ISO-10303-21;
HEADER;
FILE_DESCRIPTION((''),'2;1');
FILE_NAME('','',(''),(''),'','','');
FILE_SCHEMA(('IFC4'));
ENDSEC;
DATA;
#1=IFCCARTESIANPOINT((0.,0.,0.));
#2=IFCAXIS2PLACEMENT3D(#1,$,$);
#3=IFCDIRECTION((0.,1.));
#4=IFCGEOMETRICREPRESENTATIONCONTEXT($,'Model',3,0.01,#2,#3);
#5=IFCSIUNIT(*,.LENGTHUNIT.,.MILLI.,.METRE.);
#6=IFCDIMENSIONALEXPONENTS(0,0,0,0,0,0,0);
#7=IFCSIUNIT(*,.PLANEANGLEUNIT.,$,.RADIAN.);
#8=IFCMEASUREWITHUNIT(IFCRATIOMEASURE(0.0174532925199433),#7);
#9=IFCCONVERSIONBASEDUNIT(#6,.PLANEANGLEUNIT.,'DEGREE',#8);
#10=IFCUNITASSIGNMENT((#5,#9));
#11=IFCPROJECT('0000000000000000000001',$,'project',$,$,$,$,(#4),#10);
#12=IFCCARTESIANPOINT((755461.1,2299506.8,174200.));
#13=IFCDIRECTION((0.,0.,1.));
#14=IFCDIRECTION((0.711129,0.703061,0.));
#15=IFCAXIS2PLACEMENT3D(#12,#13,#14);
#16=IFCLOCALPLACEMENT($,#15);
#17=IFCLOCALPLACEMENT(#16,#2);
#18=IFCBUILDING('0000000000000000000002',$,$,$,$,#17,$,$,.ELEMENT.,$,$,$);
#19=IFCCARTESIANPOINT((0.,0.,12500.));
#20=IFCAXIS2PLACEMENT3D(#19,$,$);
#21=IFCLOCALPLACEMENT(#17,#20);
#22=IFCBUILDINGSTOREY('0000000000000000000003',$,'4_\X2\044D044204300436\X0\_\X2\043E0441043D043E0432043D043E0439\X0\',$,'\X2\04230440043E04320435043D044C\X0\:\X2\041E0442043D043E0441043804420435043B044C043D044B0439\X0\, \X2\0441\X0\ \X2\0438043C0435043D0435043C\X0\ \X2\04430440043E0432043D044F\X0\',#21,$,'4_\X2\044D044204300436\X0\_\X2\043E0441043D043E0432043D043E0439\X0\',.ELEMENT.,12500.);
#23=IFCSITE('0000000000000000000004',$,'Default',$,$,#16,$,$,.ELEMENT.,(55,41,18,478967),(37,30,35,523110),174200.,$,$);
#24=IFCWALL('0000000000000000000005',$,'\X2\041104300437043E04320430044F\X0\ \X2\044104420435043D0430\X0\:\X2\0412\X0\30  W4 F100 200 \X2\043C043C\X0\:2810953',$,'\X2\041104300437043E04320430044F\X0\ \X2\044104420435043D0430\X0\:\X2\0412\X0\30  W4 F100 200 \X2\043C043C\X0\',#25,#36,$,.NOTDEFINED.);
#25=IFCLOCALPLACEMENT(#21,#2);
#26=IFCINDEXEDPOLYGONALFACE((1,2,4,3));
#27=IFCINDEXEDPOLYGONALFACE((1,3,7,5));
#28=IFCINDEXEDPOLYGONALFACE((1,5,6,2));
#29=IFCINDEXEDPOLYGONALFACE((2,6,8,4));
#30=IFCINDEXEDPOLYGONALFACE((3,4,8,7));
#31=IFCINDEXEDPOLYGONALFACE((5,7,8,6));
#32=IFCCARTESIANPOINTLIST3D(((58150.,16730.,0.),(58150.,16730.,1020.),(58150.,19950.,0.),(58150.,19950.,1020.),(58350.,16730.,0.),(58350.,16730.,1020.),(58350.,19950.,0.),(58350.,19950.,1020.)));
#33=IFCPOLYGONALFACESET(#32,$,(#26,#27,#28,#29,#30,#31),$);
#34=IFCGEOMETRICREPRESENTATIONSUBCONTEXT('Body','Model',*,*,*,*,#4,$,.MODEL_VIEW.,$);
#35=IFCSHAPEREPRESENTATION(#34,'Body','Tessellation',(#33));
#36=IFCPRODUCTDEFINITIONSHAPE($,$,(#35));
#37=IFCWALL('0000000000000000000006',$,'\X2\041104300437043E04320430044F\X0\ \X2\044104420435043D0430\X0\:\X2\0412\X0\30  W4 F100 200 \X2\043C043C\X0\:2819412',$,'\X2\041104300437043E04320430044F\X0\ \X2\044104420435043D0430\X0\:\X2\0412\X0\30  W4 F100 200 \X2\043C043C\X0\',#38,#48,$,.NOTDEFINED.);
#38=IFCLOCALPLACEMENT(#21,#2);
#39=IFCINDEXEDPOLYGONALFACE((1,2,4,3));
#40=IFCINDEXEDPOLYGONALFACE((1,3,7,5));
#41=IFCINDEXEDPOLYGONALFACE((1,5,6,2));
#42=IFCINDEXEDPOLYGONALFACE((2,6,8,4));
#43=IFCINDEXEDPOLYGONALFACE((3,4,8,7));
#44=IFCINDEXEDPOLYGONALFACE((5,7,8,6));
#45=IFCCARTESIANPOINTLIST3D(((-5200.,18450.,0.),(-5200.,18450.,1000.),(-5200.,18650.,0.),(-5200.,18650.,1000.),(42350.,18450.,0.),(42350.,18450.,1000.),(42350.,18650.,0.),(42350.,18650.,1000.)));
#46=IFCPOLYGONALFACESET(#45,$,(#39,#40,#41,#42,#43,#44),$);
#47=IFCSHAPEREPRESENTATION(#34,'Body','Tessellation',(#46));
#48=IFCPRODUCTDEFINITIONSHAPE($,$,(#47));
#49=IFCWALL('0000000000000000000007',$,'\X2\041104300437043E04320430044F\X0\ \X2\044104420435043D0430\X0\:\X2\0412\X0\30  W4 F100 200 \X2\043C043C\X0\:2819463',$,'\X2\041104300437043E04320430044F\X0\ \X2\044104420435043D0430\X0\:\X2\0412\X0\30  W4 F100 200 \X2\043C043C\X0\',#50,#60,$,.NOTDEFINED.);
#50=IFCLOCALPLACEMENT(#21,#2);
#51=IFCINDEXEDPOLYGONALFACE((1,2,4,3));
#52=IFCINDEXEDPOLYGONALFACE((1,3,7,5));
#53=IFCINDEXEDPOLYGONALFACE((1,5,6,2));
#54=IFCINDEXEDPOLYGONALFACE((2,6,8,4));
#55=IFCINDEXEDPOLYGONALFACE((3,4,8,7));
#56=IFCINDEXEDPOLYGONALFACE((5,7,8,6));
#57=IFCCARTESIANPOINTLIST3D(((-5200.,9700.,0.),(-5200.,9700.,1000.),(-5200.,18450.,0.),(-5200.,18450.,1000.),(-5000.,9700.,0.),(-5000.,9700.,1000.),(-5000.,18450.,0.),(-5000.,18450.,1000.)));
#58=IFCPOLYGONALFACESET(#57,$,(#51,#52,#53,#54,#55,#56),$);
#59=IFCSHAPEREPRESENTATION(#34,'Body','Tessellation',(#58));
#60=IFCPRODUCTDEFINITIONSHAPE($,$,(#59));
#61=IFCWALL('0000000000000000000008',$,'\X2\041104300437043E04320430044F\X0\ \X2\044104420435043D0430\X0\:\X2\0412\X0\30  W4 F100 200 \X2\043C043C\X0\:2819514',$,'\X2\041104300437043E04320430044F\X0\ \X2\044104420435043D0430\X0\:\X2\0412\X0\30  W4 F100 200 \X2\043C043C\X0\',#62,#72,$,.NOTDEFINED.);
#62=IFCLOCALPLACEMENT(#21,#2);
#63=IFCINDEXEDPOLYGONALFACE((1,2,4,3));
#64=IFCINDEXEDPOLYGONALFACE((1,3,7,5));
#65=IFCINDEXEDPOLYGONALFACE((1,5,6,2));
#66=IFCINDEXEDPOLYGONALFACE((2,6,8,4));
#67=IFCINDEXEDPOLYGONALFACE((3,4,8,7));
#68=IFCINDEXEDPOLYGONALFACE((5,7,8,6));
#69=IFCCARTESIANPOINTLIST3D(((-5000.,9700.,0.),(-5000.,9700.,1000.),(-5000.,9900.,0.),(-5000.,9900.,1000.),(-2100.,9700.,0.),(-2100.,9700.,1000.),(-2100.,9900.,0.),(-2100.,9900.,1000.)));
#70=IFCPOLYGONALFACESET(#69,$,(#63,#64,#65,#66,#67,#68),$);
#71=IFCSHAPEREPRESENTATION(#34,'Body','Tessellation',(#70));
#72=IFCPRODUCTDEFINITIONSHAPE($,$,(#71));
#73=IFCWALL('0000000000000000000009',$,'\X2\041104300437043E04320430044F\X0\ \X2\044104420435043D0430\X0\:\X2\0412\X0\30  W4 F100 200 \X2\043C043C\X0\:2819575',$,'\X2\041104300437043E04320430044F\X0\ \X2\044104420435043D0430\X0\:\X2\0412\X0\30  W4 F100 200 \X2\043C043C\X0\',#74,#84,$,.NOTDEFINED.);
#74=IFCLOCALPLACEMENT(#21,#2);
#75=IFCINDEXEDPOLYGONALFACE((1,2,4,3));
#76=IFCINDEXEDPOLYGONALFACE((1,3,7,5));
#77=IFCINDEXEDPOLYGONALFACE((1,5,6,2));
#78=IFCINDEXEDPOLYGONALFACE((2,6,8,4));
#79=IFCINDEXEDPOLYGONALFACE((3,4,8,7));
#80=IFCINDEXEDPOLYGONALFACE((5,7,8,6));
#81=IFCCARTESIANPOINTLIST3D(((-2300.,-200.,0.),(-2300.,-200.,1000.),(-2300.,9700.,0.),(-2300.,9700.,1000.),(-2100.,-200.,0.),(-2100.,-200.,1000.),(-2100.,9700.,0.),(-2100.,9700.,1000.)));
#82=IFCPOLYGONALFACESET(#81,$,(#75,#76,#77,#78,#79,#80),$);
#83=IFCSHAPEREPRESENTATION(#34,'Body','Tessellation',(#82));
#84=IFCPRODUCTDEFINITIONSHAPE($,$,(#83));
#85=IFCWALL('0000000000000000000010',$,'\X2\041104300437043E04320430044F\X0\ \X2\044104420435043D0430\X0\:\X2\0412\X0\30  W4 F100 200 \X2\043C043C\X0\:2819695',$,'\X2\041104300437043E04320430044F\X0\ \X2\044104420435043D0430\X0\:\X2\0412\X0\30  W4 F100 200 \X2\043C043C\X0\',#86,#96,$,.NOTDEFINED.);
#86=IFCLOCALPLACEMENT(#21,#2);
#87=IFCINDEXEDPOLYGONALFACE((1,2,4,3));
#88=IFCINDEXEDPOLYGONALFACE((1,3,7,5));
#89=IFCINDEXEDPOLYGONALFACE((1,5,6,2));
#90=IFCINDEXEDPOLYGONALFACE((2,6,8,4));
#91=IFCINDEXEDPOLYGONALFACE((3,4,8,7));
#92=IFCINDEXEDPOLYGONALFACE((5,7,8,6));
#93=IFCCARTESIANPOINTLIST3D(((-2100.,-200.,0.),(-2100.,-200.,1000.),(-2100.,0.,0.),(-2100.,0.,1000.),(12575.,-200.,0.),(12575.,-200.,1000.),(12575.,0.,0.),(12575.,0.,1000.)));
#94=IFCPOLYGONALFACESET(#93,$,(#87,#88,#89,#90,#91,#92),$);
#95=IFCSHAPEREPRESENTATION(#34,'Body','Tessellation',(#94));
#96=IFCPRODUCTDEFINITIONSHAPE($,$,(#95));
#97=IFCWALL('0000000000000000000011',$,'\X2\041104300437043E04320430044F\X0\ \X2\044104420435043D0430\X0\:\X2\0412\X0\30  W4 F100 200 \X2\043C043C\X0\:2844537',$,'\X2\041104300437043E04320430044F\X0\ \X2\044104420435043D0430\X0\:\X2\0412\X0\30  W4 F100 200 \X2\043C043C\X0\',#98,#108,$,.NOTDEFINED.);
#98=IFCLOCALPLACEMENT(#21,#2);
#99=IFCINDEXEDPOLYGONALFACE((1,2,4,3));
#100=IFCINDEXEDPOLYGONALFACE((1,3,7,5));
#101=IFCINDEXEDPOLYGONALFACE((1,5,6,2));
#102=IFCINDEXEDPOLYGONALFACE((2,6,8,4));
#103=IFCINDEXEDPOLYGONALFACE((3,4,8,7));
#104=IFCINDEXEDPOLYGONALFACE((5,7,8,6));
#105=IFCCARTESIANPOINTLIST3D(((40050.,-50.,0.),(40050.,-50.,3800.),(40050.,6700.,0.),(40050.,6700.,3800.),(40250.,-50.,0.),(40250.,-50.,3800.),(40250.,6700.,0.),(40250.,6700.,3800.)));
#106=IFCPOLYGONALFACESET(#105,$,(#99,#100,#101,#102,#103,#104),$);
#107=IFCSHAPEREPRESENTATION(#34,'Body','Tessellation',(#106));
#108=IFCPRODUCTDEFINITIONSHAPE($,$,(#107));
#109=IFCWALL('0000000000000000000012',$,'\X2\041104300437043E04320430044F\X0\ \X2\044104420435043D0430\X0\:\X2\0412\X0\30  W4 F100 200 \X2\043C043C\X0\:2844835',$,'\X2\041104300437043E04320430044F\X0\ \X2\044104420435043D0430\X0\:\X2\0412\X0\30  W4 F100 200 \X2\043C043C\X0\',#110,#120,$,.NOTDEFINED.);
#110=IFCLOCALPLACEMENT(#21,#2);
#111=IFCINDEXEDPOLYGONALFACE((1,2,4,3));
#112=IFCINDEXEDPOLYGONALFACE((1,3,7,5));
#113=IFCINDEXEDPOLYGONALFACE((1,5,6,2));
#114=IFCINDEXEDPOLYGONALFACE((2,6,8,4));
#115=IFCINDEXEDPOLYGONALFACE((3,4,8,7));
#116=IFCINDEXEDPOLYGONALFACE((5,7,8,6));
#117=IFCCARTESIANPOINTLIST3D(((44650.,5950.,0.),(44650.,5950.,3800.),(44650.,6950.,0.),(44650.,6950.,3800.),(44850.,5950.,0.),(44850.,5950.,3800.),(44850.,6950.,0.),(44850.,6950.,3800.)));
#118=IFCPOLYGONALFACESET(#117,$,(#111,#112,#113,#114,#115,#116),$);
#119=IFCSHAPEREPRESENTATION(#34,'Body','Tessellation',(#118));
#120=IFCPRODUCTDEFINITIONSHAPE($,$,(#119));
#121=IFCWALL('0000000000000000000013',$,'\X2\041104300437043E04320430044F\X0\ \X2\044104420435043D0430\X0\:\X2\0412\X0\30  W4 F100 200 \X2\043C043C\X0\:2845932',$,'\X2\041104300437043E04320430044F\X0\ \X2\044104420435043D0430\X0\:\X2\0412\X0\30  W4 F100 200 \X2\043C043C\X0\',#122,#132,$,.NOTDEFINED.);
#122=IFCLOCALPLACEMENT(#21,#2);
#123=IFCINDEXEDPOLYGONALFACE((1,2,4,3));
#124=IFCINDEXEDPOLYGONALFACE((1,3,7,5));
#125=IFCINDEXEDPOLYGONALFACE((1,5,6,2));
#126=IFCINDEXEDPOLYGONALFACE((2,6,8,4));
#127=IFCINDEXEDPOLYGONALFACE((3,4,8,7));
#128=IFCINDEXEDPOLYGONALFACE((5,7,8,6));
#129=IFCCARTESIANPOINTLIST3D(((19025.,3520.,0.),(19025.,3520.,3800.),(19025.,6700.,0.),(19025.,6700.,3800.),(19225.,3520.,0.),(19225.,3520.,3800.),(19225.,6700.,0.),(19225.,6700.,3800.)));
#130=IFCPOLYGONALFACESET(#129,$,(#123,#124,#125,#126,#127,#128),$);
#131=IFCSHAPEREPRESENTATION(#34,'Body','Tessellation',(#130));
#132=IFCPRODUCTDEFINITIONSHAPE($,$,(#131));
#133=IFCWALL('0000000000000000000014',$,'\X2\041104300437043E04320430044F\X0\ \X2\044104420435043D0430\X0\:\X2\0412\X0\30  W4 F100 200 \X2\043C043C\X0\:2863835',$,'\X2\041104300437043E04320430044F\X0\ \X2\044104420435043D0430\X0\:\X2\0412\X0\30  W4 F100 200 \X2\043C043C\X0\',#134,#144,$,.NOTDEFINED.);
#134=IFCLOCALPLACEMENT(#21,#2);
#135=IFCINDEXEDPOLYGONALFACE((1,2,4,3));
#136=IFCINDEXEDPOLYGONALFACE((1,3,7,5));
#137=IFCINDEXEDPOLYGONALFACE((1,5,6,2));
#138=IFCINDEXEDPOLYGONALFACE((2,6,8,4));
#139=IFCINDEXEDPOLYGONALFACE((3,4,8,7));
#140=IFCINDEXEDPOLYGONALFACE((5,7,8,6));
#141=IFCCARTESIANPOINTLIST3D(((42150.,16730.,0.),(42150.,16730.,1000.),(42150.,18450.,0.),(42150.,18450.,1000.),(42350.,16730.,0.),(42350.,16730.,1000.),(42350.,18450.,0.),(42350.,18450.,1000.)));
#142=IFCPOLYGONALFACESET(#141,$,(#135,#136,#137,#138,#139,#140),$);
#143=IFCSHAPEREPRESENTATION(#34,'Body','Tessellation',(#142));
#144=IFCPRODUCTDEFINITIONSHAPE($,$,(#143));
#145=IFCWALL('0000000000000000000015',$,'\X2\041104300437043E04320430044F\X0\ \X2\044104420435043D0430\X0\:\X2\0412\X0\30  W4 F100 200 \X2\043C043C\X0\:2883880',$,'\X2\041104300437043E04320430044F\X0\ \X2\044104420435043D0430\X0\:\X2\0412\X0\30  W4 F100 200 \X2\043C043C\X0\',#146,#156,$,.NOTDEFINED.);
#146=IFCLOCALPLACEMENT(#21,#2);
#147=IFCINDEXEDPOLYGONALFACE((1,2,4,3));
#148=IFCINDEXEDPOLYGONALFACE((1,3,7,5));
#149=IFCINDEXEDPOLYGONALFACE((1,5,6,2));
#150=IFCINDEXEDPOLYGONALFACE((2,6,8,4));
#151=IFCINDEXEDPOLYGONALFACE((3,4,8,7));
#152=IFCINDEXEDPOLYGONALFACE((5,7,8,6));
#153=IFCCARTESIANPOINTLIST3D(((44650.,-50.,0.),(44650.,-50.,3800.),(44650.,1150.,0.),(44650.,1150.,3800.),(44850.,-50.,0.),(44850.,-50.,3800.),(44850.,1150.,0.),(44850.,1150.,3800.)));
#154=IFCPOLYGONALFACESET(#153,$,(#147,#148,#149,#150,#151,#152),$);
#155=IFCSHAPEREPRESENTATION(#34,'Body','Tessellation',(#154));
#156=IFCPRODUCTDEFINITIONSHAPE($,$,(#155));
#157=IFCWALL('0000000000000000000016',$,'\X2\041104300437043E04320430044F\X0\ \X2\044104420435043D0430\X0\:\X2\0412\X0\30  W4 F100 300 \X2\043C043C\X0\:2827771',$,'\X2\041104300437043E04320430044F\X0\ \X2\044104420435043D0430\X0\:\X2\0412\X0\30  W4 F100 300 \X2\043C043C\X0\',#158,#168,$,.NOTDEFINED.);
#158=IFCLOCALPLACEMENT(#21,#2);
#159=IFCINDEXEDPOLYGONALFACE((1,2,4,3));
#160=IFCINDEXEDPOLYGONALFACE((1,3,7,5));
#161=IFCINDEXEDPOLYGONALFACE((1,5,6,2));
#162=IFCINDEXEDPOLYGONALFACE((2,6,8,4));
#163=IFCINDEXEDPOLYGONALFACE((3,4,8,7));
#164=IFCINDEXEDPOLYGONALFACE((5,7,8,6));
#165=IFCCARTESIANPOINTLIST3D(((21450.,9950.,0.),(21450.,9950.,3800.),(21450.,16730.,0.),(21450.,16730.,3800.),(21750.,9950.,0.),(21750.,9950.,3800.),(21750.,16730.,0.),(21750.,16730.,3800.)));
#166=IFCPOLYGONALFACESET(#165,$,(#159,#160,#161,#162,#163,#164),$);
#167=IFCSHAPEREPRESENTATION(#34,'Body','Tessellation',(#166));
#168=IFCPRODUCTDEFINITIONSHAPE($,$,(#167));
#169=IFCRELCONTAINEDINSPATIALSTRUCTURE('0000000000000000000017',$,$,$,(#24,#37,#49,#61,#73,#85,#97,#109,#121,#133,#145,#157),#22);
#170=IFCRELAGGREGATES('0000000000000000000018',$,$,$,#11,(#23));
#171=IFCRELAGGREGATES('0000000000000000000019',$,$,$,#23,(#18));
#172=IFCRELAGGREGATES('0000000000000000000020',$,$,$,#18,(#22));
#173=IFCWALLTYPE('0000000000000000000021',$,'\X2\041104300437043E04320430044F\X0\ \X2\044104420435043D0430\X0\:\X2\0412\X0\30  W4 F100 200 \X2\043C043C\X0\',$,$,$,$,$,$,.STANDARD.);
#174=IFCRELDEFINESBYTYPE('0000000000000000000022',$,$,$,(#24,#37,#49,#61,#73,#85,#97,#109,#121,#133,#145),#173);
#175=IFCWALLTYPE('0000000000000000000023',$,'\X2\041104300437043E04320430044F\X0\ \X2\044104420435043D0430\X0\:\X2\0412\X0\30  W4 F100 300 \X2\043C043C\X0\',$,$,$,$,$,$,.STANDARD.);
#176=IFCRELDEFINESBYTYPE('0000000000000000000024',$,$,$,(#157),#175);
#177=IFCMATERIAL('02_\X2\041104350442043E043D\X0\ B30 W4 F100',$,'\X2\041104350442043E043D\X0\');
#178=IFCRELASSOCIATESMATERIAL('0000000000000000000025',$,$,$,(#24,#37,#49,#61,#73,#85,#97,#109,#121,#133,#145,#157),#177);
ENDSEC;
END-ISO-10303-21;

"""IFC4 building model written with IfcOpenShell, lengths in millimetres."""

from ifc_helpers import new_model, entity, si_unit, converted_unit, direction, frame, origin, place, context, subcontext, project, spatial, indexed_curve, outline, extrude, material, type_object, element, save


model = new_model("IFC4")

# Units and contexts
model_context = context("Model", 3, precision=0.01, world=origin(), true_north=direction((0.0, 1.0)))
body_context = subcontext(model_context, "Body", "Model", "MODEL_VIEW")
ifc_project = project(units=[si_unit("LENGTHUNIT", "METRE", prefix="MILLI"), converted_unit("PLANEANGLEUNIT", "DEGREE", entity("IfcRatioMeasure", 0.0174532925199433), si_unit("PLANEANGLEUNIT", "RADIAN"), dimensions=[0, 0, 0, 0, 0, 0, 0])], contexts=[model_context])

# Site, building, storey
site_placement = place(None, frame((755461.1, 2299506.8, 174200.0), z_axis=(0.0, 0.0, 1.0), x_axis=(0.711129, 0.703061, 0.0)))
site = spatial("IfcSite", under=ifc_project, at=site_placement, Name="Default", CompositionType="ELEMENT", RefLatitude=(55, 41, 18, 478967), RefLongitude=(37, 30, 35, 523110), RefElevation=174200.0)
building_placement = place(site_placement, origin())
building = spatial("IfcBuilding", under=site, at=building_placement, CompositionType="ELEMENT")
storey_placement = place(building_placement, frame((0.0, 0.0, 12500.0)))
storey = spatial("IfcBuildingStorey", under=building, at=storey_placement, Name="4_этаж_основной", ObjectType="Уровень:Относительный, с именем уровня", LongName="4_этаж_основной", CompositionType="ELEMENT", Elevation=12500.0)

# Shared definitions
ifc_material_1 = material(Name="02_Бетон B30 W4 F100", Category="Бетон")

# Walls
wall_type_1 = type_object("IfcWallType", Name="Базовая стена:В30  W4 F100 200 мм", PredefinedType="STANDARD")
wall_1_placement = place(storey_placement, frame((58250.0, 19950.0, 0.0), z_axis=(0.0, 0.0, 1.0), x_axis=(0.0, -1.0, 0.0)))
element("IfcWall", 1, at=wall_1_placement, inside=storey, type_object=wall_type_1, material=ifc_material_1, Name="Базовая стена:В30  W4 F100 200 мм:2810953", ObjectType="Базовая стена:В30  W4 F100 200 мм", PredefinedType="NOTDEFINED", context=body_context, shape_type="SweptSolid", body=[
    extrude(outline(indexed_curve([(3220.0, 100.0), (0.0, 100.0), (0.0, -100.0), (3220.0, -100.0), (3220.0, 100.0)], self_intersect=False)), origin(), (0.0, 0.0, 1.0), 1020.0),
])
wall_2_placement = place(storey_placement, frame((42350.0, 18550.0, 0.0), z_axis=(0.0, 0.0, 1.0), x_axis=(-1.0, 0.0, 0.0)))
element("IfcWall", 2, at=wall_2_placement, inside=storey, type_object=wall_type_1, material=ifc_material_1, Name="Базовая стена:В30  W4 F100 200 мм:2819412", ObjectType="Базовая стена:В30  W4 F100 200 мм", PredefinedType="NOTDEFINED", context=body_context, shape_type="SweptSolid", body=[
    extrude(outline(indexed_curve([(47550.0, 100.0), (0.0, 100.0), (0.0, -100.0), (47550.0, -100.0), (47550.0, 100.0)], self_intersect=False)), origin(), (0.0, 0.0, 1.0), 1000.0),
])
wall_3_placement = place(storey_placement, frame((-5100.0, 18450.0, 0.0), z_axis=(0.0, 0.0, 1.0), x_axis=(0.0, -1.0, 0.0)))
element("IfcWall", 3, at=wall_3_placement, inside=storey, type_object=wall_type_1, material=ifc_material_1, Name="Базовая стена:В30  W4 F100 200 мм:2819463", ObjectType="Базовая стена:В30  W4 F100 200 мм", PredefinedType="NOTDEFINED", context=body_context, shape_type="SweptSolid", body=[
    extrude(outline(indexed_curve([(8750.0, 100.0), (0.0, 100.0), (0.0, -100.0), (8750.0, -100.0), (8750.0, 100.0)], self_intersect=False)), origin(), (0.0, 0.0, 1.0), 1000.0),
])
wall_4_placement = place(storey_placement, frame((-5000.0, 9800.0, 0.0)))
element("IfcWall", 4, at=wall_4_placement, inside=storey, type_object=wall_type_1, material=ifc_material_1, Name="Базовая стена:В30  W4 F100 200 мм:2819514", ObjectType="Базовая стена:В30  W4 F100 200 мм", PredefinedType="NOTDEFINED", context=body_context, shape_type="SweptSolid", body=[
    extrude(outline(indexed_curve([(2900.0, 100.0), (0.0, 100.0), (0.0, -100.0), (2900.0, -100.0), (2900.0, 100.0)], self_intersect=False)), origin(), (0.0, 0.0, 1.0), 1000.0),
])
wall_5_placement = place(storey_placement, frame((-2200.0, 9700.0, 0.0), z_axis=(0.0, 0.0, 1.0), x_axis=(0.0, -1.0, 0.0)))
element("IfcWall", 5, at=wall_5_placement, inside=storey, type_object=wall_type_1, material=ifc_material_1, Name="Базовая стена:В30  W4 F100 200 мм:2819575", ObjectType="Базовая стена:В30  W4 F100 200 мм", PredefinedType="NOTDEFINED", context=body_context, shape_type="SweptSolid", body=[
    extrude(outline(indexed_curve([(9900.0, 100.0), (0.0, 100.0), (0.0, -100.0), (9900.0, -100.0), (9900.0, 100.0)], self_intersect=False)), origin(), (0.0, 0.0, 1.0), 1000.0),
])
wall_6_placement = place(storey_placement, frame((-2100.0, -100.0, 0.0)))
element("IfcWall", 6, at=wall_6_placement, inside=storey, type_object=wall_type_1, material=ifc_material_1, Name="Базовая стена:В30  W4 F100 200 мм:2819695", ObjectType="Базовая стена:В30  W4 F100 200 мм", PredefinedType="NOTDEFINED", context=body_context, shape_type="SweptSolid", body=[
    extrude(outline(indexed_curve([(14675.0, 100.0), (0.0, 100.0), (0.0, -100.0), (14675.0, -100.0), (14675.0, 100.0)], self_intersect=False)), origin(), (0.0, 0.0, 1.0), 1000.0),
])
wall_7_placement = place(storey_placement, frame((40150.0, -50.0, 0.0), z_axis=(0.0, 0.0, 1.0), x_axis=(0.0, 1.0, 0.0)))
element("IfcWall", 7, at=wall_7_placement, inside=storey, type_object=wall_type_1, material=ifc_material_1, Name="Базовая стена:В30  W4 F100 200 мм:2844537", ObjectType="Базовая стена:В30  W4 F100 200 мм", PredefinedType="NOTDEFINED", context=body_context, shape_type="SweptSolid", body=[
    extrude(outline(indexed_curve([(6750.0, 100.0), (0.0, 100.0), (0.0, -100.0), (6750.0, -100.0), (6750.0, 100.0)], self_intersect=False)), origin(), (0.0, 0.0, 1.0), 3800.0),
])
wall_8_placement = place(storey_placement, frame((44750.0, 6950.0, 0.0), z_axis=(0.0, 0.0, 1.0), x_axis=(0.0, -1.0, 0.0)))
element("IfcWall", 8, at=wall_8_placement, inside=storey, type_object=wall_type_1, material=ifc_material_1, Name="Базовая стена:В30  W4 F100 200 мм:2844835", ObjectType="Базовая стена:В30  W4 F100 200 мм", PredefinedType="NOTDEFINED", context=body_context, shape_type="SweptSolid", body=[
    extrude(outline(indexed_curve([(1000.0, 100.0), (0.0, 100.0), (0.0, -100.0), (1000.0, -100.0), (1000.0, 100.0)], self_intersect=False)), origin(), (0.0, 0.0, 1.0), 3800.0),
])
wall_9_placement = place(storey_placement, frame((19125.0, 3520.0, 0.0), z_axis=(0.0, 0.0, 1.0), x_axis=(0.0, 1.0, 0.0)))
element("IfcWall", 9, at=wall_9_placement, inside=storey, type_object=wall_type_1, material=ifc_material_1, Name="Базовая стена:В30  W4 F100 200 мм:2845932", ObjectType="Базовая стена:В30  W4 F100 200 мм", PredefinedType="NOTDEFINED", context=body_context, shape_type="SweptSolid", body=[
    extrude(outline(indexed_curve([(3180.0, 100.0), (0.0, 100.0), (0.0, -100.0), (3180.0, -100.0), (3180.0, 100.0)], self_intersect=False)), origin(), (0.0, 0.0, 1.0), 3800.0),
])
wall_10_placement = place(storey_placement, frame((42250.0, 18450.0, 0.0), z_axis=(0.0, 0.0, 1.0), x_axis=(0.0, -1.0, 0.0)))
element("IfcWall", 10, at=wall_10_placement, inside=storey, type_object=wall_type_1, material=ifc_material_1, Name="Базовая стена:В30  W4 F100 200 мм:2863835", ObjectType="Базовая стена:В30  W4 F100 200 мм", PredefinedType="NOTDEFINED", context=body_context, shape_type="SweptSolid", body=[
    extrude(outline(indexed_curve([(1720.0, 100.0), (0.0, 100.0), (0.0, -100.0), (1720.0, -100.0), (1720.0, 100.0)], self_intersect=False)), origin(), (0.0, 0.0, 1.0), 1000.0),
])
wall_11_placement = place(storey_placement, frame((44750.0, 1150.0, 0.0), z_axis=(0.0, 0.0, 1.0), x_axis=(0.0, -1.0, 0.0)))
element("IfcWall", 11, at=wall_11_placement, inside=storey, type_object=wall_type_1, material=ifc_material_1, Name="Базовая стена:В30  W4 F100 200 мм:2883880", ObjectType="Базовая стена:В30  W4 F100 200 мм", PredefinedType="NOTDEFINED", context=body_context, shape_type="SweptSolid", body=[
    extrude(outline(indexed_curve([(1200.0, 100.0), (0.0, 100.0), (0.0, -100.0), (1200.0, -100.0), (1200.0, 100.0)], self_intersect=False)), origin(), (0.0, 0.0, 1.0), 3800.0),
])
wall_type_2 = type_object("IfcWallType", Name="Базовая стена:В30  W4 F100 300 мм", PredefinedType="STANDARD")
wall_12_placement = place(storey_placement, frame((21600.0, 16730.0, 0.0), z_axis=(0.0, 0.0, 1.0), x_axis=(0.0, -1.0, 0.0)))
element("IfcWall", 12, at=wall_12_placement, inside=storey, type_object=wall_type_2, material=ifc_material_1, Name="Базовая стена:В30  W4 F100 300 мм:2827771", ObjectType="Базовая стена:В30  W4 F100 300 мм", PredefinedType="NOTDEFINED", context=body_context, shape_type="SweptSolid", body=[
    extrude(outline(indexed_curve([(6780.0, 150.0), (0.0, 150.0), (0.0, -150.0), (6780.0, -150.0), (6780.0, 150.0)], self_intersect=False)), origin(), (0.0, 0.0, 1.0), 3800.0),
])

save(model, "model.ifc")
